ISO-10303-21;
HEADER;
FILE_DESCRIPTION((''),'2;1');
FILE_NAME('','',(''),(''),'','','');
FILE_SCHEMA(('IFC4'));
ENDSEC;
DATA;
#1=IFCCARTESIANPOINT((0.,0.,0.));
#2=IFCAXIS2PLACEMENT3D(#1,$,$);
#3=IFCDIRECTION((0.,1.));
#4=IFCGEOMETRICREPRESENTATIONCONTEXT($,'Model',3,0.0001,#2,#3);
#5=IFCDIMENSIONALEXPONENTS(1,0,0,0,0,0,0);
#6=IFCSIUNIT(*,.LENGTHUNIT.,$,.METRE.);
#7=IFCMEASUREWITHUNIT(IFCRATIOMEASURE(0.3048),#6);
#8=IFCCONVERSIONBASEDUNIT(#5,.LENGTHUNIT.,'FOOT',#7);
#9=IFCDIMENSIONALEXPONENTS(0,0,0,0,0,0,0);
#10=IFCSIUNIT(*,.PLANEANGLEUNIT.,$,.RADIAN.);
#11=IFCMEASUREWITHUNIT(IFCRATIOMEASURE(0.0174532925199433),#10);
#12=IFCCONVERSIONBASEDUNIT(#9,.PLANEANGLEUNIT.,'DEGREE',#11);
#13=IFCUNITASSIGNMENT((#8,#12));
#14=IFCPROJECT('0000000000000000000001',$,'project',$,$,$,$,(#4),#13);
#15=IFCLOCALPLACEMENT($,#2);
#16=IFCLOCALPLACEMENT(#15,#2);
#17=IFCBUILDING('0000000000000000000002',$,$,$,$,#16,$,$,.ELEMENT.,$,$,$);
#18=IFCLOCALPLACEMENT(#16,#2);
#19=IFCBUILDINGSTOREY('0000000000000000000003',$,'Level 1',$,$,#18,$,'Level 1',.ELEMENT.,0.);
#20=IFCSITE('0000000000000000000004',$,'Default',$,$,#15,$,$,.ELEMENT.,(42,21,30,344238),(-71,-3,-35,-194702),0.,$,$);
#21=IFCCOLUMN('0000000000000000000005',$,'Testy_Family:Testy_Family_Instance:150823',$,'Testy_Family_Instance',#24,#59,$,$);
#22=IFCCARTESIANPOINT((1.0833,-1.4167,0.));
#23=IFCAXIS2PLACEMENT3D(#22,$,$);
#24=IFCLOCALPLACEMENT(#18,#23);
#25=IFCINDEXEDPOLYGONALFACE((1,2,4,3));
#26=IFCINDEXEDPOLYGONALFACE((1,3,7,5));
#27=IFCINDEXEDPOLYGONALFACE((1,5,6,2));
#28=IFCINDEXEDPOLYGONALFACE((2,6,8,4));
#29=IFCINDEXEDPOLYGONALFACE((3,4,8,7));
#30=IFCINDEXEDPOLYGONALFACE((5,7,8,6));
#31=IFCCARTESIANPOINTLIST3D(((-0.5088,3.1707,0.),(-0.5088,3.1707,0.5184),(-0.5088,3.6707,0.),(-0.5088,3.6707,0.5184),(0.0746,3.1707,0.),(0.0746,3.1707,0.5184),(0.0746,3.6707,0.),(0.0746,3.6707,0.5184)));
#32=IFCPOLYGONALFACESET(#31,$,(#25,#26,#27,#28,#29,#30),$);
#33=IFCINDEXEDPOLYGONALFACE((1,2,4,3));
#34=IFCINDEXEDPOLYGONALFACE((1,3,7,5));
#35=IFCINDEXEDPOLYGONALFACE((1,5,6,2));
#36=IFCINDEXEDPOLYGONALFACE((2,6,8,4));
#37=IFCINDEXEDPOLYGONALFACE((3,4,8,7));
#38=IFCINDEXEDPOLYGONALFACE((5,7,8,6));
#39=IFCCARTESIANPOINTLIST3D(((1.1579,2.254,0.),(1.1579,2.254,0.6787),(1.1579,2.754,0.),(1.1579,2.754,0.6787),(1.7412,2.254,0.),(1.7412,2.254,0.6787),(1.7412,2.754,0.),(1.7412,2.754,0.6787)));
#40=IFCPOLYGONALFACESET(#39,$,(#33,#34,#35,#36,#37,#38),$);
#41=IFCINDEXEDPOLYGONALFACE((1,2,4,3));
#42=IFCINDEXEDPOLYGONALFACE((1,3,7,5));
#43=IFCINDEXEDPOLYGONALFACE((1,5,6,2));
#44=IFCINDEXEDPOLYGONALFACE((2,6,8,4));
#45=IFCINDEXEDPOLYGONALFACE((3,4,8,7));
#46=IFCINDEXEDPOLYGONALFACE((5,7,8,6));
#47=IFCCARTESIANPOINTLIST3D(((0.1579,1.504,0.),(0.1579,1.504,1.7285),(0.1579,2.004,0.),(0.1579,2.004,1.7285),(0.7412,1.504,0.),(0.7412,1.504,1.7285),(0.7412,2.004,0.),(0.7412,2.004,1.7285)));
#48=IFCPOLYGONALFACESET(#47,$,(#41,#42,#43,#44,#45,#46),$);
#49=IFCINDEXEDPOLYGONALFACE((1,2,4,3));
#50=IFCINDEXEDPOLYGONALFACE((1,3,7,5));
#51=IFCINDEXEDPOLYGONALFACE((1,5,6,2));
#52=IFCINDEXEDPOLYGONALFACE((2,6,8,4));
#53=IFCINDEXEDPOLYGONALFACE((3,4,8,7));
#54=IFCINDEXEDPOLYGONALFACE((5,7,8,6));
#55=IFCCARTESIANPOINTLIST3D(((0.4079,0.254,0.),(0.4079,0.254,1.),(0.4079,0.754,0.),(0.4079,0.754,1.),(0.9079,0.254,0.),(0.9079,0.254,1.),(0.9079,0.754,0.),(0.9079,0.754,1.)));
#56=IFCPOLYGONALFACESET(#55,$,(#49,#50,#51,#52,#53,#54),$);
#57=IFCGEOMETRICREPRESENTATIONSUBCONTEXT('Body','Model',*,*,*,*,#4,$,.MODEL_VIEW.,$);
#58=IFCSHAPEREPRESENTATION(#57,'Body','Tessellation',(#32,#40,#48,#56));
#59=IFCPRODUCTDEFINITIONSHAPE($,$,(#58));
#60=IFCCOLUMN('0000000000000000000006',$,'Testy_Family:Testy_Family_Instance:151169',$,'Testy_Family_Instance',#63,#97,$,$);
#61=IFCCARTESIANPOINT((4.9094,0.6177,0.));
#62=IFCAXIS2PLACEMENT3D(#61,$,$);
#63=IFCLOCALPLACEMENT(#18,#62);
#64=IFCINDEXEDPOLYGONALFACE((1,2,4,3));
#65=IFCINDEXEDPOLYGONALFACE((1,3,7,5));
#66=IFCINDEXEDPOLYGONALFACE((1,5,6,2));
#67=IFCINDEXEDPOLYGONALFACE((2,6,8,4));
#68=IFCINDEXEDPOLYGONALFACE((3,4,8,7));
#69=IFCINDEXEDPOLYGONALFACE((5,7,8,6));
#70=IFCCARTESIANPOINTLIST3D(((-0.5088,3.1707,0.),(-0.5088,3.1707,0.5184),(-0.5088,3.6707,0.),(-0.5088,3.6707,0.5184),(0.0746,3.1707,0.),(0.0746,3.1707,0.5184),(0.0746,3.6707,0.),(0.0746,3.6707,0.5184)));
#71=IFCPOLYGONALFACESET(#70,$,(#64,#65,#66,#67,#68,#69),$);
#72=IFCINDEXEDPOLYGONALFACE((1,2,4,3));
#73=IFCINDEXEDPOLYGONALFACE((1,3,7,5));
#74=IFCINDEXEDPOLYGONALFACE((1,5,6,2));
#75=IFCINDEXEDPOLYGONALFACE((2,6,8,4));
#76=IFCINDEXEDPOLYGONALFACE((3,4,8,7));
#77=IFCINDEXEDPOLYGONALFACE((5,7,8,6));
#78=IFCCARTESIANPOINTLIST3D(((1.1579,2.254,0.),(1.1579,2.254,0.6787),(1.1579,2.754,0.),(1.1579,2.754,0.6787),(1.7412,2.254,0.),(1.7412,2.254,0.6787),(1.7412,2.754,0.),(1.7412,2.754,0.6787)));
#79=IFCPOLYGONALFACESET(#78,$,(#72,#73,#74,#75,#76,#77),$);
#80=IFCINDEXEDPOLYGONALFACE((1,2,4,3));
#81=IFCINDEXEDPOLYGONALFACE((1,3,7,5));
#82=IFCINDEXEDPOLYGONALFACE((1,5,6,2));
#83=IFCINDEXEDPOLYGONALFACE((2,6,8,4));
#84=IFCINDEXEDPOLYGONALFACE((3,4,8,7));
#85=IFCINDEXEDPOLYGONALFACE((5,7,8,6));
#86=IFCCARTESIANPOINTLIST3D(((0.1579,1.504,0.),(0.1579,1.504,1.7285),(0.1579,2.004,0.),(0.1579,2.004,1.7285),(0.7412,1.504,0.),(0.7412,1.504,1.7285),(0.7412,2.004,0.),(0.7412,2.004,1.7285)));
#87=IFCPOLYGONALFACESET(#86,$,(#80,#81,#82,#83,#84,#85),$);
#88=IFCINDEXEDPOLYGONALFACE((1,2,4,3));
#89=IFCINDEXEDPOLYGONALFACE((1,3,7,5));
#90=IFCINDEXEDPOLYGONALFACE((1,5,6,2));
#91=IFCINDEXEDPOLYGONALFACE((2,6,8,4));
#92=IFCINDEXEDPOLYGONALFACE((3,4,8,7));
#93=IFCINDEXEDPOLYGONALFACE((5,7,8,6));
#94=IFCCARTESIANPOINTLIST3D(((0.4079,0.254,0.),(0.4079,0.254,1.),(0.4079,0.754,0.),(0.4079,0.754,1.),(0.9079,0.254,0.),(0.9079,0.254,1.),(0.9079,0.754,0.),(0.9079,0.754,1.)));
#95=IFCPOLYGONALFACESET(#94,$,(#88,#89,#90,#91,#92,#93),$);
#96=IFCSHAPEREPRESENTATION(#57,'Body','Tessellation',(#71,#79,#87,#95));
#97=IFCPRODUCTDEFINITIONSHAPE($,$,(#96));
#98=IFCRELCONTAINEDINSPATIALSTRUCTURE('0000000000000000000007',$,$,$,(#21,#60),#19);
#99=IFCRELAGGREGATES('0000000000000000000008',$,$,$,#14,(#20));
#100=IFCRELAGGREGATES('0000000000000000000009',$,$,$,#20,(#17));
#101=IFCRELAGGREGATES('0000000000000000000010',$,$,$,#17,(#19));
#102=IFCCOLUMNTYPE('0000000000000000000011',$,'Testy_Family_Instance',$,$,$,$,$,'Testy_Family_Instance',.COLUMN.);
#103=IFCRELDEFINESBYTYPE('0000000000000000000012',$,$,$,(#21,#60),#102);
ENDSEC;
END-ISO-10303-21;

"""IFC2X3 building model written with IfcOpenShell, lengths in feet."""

from ifc_helpers import new_model, entity, si_unit, converted_unit, direction, frame, frame_2d, origin, origin_2d_with_axis, place, context, subcontext, project, spatial, rectangle, extrude, source, transform, mapped, type_object, type_shapes, element, save


model = new_model("IFC2X3")

# Units and contexts
model_context = context("Model", 3, precision=0.0001, world=origin(), true_north=direction((0.0, 1.0)))
body_context = subcontext(model_context, "Body", "Model", "MODEL_VIEW")
ifc_project = project(units=[converted_unit("LENGTHUNIT", "FOOT", entity("IfcRatioMeasure", 0.3048), si_unit("LENGTHUNIT", "METRE"), dimensions=[1, 0, 0, 0, 0, 0, 0]), converted_unit("PLANEANGLEUNIT", "DEGREE", entity("IfcRatioMeasure", 0.0174532925199433), si_unit("PLANEANGLEUNIT", "RADIAN"), dimensions=[0, 0, 0, 0, 0, 0, 0])], contexts=[model_context])

# Site, building, storey
site_placement = place(None, origin())
site = spatial("IfcSite", under=ifc_project, at=site_placement, Name="Default", CompositionType="ELEMENT", RefLatitude=(42, 21, 30, 344238), RefLongitude=(-71, -3, -35, -194702), RefElevation=0.0)
building_placement = place(site_placement, origin())
building = spatial("IfcBuilding", under=site, at=building_placement, CompositionType="ELEMENT")
storey_placement = place(building_placement, origin())
storey = spatial("IfcBuildingStorey", under=building, at=storey_placement, Name="Level 1", LongName="Level 1", CompositionType="ELEMENT", Elevation=0.0)

# Columns
column_type = type_object("IfcColumnType", Name="Testy_Family_Instance", ElementType="Testy_Family_Instance", PredefinedType="COLUMN")
shared_shape = source(origin(), body_context, "Body", "SweptSolid", [
    extrude(rectangle(XDim=0.5, YDim=0.5833, at=origin_2d_with_axis()), frame((-0.2171, 3.4207, 0.0), z_axis=(0.0, 0.0, 1.0), x_axis=(0.0, -1.0, 0.0)), (0.0, 0.0, 1.0), 0.5184),
    extrude(rectangle(XDim=0.5, YDim=0.5833, at=frame_2d((0.0, 0.0), x_axis=(1.0, 0.0))), frame((1.4496, 2.504, 0.0), z_axis=(0.0, 0.0, 1.0), x_axis=(0.0, -1.0, 0.0)), (0.0, 0.0, 1.0), 0.6787),
    extrude(rectangle(XDim=0.5, YDim=0.5833, at=origin_2d_with_axis()), frame((0.4496, 1.754, 0.0), z_axis=(0.0, 0.0, 1.0), x_axis=(0.0, -1.0, 0.0)), (0.0, 0.0, 1.0), 1.7285),
    extrude(rectangle(XDim=0.5, YDim=0.5, at=frame_2d((0.0, 0.0), x_axis=(1.0, 0.0))), frame((0.6579, 0.504, 0.0), z_axis=(0.0, 0.0, 1.0), x_axis=(0.0, -1.0, 0.0)), (0.0, 0.0, 1.0), 1.0),
])
type_shapes(column_type, [shared_shape])
for number, where, name in (
    (1, (1.0833, -1.4167, 0.0), "Testy_Family:Testy_Family_Instance:150823"),
    (2, (4.9094, 0.6177, 0.0), "Testy_Family:Testy_Family_Instance:151169"),
):
    element("IfcColumn", number, at=place(storey_placement, frame(where)), inside=storey, type_object=column_type, Name=name, ObjectType="Testy_Family_Instance", context=body_context, shape_type="MappedRepresentation", body=[
        mapped(shared_shape, transform((0.0, 0.0, 0.0), scale=1.0)),
    ])

save(model, "model.ifc")
